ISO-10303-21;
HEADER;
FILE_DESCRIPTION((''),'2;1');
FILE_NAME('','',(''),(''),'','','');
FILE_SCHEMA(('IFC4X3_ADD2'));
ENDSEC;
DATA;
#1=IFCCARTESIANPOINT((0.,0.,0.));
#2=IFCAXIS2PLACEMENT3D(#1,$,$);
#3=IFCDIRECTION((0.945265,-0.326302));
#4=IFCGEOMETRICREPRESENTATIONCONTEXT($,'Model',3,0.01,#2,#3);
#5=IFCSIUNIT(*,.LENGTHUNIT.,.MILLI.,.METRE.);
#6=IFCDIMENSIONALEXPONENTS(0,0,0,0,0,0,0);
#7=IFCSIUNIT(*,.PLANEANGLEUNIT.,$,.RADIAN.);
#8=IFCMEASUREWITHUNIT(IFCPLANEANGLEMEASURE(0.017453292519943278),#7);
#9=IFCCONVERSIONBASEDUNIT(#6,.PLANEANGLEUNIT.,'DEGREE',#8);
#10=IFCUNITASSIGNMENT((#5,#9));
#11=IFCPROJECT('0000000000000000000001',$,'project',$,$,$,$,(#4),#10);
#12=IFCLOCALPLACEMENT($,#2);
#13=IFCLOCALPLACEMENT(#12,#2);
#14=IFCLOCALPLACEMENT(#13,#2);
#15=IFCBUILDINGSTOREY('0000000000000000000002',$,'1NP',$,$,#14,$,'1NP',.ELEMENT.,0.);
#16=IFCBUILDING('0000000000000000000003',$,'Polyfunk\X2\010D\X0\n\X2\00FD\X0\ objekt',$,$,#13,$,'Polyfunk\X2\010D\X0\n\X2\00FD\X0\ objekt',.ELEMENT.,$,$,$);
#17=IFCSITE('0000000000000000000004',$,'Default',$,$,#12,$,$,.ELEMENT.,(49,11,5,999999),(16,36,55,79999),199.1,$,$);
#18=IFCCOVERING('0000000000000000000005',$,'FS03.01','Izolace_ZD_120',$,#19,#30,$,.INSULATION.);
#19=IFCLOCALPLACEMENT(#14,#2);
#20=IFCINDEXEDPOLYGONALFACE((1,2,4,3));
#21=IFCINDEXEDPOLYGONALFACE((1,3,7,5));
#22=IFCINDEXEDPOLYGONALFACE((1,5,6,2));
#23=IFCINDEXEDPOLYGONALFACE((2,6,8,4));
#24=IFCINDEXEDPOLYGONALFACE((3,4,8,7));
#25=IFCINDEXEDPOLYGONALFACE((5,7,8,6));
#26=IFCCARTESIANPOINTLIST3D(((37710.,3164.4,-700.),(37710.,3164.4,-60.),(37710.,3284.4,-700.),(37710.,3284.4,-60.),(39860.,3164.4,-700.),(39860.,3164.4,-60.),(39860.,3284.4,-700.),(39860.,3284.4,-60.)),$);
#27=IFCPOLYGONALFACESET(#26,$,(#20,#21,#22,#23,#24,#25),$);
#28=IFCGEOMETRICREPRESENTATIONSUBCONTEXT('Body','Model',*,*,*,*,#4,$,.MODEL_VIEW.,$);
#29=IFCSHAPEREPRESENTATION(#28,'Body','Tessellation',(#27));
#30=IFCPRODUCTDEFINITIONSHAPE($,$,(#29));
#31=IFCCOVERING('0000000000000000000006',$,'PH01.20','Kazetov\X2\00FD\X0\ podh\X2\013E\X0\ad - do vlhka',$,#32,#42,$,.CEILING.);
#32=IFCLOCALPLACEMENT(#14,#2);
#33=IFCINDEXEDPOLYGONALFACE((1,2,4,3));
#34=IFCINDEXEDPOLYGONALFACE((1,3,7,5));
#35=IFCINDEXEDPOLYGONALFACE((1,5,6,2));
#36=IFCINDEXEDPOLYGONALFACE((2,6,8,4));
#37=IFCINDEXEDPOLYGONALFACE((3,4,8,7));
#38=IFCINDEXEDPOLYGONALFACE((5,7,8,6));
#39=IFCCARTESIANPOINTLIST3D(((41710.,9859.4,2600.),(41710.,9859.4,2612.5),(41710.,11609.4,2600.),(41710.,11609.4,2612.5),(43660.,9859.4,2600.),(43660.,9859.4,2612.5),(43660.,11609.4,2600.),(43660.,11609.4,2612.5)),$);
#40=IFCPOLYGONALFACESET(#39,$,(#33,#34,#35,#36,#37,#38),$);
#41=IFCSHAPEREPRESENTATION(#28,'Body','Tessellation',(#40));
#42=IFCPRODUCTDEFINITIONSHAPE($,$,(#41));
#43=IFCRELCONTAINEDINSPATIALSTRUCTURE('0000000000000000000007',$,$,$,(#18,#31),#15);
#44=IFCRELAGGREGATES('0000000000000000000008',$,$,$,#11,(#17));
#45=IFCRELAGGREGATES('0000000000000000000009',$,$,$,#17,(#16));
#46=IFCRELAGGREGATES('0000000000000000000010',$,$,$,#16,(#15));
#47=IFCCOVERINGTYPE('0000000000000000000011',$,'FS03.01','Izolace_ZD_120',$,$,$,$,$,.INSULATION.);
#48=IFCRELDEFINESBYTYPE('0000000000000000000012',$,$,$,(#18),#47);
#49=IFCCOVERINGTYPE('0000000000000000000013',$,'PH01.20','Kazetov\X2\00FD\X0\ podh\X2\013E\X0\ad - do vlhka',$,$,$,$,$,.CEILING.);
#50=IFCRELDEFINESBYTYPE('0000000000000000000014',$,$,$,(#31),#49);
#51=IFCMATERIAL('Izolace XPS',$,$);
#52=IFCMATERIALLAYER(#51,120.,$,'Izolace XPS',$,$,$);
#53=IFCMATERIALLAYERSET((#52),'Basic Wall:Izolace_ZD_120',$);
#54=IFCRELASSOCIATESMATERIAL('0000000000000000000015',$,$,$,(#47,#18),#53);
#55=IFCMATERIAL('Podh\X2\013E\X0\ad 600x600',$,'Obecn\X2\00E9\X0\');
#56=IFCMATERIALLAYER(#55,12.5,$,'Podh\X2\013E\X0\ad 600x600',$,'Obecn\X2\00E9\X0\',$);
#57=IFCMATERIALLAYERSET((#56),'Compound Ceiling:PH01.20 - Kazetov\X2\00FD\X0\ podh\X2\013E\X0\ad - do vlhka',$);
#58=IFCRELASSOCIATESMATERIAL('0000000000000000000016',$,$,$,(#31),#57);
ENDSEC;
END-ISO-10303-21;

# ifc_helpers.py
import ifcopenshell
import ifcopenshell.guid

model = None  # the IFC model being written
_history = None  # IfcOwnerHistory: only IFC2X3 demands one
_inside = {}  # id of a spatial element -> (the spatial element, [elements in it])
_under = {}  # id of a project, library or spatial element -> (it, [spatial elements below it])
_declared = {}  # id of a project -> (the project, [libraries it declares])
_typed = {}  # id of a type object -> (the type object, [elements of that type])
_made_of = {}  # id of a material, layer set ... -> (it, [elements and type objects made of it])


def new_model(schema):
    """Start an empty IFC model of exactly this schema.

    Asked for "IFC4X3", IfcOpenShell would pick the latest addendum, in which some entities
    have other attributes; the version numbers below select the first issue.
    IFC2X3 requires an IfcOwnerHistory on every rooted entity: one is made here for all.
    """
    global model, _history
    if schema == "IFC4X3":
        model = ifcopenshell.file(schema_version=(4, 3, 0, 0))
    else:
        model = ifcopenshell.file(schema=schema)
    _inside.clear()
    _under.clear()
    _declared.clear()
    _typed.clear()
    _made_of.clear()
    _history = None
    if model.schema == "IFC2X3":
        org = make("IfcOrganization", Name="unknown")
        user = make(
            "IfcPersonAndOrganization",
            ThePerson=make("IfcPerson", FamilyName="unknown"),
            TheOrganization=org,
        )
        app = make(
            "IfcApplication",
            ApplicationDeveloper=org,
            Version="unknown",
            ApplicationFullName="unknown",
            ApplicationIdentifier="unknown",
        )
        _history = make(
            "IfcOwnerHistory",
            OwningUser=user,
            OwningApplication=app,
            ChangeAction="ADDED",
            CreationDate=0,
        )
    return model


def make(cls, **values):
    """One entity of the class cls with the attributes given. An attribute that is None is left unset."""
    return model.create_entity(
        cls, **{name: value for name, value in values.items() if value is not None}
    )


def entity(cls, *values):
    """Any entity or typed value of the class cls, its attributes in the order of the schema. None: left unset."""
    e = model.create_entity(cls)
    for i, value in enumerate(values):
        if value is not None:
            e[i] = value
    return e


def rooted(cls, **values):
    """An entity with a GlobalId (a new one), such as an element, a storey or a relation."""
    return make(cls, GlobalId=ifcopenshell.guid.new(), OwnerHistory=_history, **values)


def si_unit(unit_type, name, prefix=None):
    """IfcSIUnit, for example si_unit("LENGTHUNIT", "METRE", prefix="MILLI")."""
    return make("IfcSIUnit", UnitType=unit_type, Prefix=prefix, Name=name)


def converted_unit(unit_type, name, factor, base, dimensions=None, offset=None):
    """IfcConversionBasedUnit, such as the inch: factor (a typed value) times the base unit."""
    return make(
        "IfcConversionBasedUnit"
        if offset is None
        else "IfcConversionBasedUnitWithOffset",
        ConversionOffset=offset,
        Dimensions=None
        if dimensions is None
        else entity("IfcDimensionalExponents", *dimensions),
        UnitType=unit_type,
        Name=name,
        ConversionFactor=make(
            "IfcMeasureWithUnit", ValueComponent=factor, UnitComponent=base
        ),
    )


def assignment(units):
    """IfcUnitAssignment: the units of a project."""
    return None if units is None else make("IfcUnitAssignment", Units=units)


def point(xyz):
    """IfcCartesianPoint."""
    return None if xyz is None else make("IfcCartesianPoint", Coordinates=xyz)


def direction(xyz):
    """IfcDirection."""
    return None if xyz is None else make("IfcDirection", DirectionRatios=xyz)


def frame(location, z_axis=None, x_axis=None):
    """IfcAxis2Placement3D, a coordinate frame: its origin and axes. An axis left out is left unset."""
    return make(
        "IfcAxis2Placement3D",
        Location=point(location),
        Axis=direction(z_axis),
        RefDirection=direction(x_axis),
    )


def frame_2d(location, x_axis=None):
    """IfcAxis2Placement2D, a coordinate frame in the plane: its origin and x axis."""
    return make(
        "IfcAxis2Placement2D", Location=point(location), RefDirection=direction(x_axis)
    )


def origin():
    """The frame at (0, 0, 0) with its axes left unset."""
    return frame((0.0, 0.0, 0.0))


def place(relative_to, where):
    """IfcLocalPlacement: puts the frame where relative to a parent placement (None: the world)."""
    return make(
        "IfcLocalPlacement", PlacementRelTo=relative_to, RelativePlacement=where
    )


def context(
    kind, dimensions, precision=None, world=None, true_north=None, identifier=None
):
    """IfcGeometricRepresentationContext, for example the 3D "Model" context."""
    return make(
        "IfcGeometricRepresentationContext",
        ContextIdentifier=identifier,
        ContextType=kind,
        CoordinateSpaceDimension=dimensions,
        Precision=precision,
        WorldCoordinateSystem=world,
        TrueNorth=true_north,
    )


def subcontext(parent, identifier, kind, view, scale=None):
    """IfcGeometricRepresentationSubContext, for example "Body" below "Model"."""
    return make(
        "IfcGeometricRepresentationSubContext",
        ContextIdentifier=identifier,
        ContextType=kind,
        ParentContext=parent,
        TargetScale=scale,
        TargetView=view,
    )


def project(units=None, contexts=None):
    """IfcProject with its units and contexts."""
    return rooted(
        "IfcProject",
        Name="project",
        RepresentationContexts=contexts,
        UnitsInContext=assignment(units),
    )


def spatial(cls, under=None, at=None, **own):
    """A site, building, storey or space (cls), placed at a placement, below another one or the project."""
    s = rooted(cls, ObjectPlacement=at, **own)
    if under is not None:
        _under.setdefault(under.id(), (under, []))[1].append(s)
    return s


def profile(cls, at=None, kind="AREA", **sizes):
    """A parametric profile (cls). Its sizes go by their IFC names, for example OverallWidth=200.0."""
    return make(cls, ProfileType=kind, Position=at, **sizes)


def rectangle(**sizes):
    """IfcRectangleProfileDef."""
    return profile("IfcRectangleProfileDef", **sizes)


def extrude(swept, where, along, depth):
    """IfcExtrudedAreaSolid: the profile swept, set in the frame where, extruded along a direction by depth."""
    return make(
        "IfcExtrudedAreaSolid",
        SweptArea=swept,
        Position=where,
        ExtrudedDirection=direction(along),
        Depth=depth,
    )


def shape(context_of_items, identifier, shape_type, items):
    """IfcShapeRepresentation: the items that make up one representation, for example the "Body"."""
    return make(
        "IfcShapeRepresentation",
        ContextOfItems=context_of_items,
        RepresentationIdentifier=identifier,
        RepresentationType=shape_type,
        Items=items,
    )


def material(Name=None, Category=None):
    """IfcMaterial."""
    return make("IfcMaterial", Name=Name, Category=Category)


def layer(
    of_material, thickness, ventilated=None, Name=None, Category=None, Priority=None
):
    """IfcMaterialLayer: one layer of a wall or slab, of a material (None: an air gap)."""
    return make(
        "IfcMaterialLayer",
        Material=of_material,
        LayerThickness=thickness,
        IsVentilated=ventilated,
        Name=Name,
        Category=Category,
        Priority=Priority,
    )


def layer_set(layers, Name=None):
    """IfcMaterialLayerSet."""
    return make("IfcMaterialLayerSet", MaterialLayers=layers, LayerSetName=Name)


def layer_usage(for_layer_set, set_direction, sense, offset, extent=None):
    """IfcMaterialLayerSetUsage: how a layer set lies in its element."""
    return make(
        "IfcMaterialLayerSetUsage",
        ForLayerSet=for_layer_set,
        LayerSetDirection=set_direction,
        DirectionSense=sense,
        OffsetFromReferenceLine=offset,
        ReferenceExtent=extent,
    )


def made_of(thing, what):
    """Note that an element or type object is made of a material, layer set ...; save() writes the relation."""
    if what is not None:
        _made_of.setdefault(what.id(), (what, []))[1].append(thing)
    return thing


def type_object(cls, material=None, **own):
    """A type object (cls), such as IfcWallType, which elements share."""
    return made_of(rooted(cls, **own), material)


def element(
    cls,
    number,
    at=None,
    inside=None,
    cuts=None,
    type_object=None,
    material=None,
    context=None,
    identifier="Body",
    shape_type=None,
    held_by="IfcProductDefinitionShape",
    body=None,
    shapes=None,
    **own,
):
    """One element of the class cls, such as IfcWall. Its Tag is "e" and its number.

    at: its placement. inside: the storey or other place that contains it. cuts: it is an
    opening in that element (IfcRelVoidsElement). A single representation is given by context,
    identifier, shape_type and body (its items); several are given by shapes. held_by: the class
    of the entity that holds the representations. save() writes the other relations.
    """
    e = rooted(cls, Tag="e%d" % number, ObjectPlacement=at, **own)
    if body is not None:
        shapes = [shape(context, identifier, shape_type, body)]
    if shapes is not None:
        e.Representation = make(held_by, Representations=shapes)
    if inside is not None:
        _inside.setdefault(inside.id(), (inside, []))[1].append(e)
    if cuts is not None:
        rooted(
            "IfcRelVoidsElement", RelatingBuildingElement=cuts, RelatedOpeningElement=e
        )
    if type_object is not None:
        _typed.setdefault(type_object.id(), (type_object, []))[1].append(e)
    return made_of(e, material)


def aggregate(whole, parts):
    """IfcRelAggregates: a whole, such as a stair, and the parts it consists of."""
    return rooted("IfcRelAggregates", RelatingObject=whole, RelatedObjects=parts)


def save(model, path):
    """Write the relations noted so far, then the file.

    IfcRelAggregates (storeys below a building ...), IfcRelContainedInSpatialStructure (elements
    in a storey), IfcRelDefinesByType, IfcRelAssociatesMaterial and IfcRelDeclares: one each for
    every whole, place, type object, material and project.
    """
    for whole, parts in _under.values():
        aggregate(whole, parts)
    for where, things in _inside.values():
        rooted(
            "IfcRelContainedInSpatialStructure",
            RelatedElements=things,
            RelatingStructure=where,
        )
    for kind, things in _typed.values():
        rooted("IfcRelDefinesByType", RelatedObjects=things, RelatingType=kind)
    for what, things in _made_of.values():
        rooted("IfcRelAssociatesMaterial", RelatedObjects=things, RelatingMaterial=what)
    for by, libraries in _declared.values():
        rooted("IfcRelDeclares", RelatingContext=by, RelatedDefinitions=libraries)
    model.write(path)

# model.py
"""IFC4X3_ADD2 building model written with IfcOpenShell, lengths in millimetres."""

from ifc_helpers import new_model, entity, si_unit, converted_unit, direction, frame, frame_2d, origin, place, context, subcontext, project, spatial, rectangle, extrude, material, layer, layer_set, layer_usage, type_object, element, save


model = new_model("IFC4X3_ADD2")

# Units and contexts
model_context = context("Model", 3, precision=0.01, world=origin(), true_north=direction((0.945265, -0.326302)))
body_context = subcontext(model_context, "Body", "Model", "MODEL_VIEW")
ifc_project = project(units=[si_unit("LENGTHUNIT", "METRE", prefix="MILLI"), converted_unit("PLANEANGLEUNIT", "DEGREE", entity("IfcPlaneAngleMeasure", 0.017453292519943278), si_unit("PLANEANGLEUNIT", "RADIAN"), dimensions=[0, 0, 0, 0, 0, 0, 0])], contexts=[model_context])

# Site, building, storey
site_placement = place(None, origin())
site = spatial("IfcSite", under=ifc_project, at=site_placement, Name="Default", CompositionType="ELEMENT", RefLatitude=(49, 11, 5, 999999), RefLongitude=(16, 36, 55, 79999), RefElevation=199.1)
building_placement = place(site_placement, origin())
building = spatial("IfcBuilding", under=site, at=building_placement, Name="Polyfunkčný objekt", LongName="Polyfunkčný objekt", CompositionType="ELEMENT")
storey_placement = place(building_placement, origin())
storey = spatial("IfcBuildingStorey", under=building, at=storey_placement, Name="1NP", LongName="1NP", CompositionType="ELEMENT", Elevation=0.0)

# Coverings
ifc_material_1 = material(Name="Podhľad 600x600", Category="Obecné")
ifc_material_2 = material(Name="Izolace XPS")
ifc_layer_1 = layer(ifc_material_2, 120.0, Name="Izolace XPS")
ifc_layer_set_1 = layer_set([ifc_layer_1], Name="Basic Wall:Izolace_ZD_120")
covering_type_1 = type_object("IfcCoveringType", Name="FS03.01", Description="Izolace_ZD_120", PredefinedType="INSULATION", material=ifc_layer_set_1)
covering_1_placement = place(storey_placement, frame((37710.0, 3224.4, -700.0)))
element("IfcCovering", 1, at=covering_1_placement, inside=storey, type_object=covering_type_1, material=ifc_layer_set_1, Name="FS03.01", Description="Izolace_ZD_120", PredefinedType="INSULATION", context=body_context, shape_type="SweptSolid", body=[
    extrude(rectangle(XDim=2150.0, YDim=120.0, at=frame_2d((1075.0, 0.0), x_axis=(-1.0, 0.0))), origin(), (0.0, 0.0, 1.0), 640.0),
])
ifc_layer_2 = layer(ifc_material_1, 12.5, Name="Podhľad 600x600", Category="Obecné")
ifc_layer_set_2 = layer_set([ifc_layer_2], Name="Compound Ceiling:PH01.20 - Kazetový podhľad - do vlhka")
ifc_layer_usage_1 = layer_usage(ifc_layer_set_2, "AXIS3", "NEGATIVE", 0.0)
covering_type_2 = type_object("IfcCoveringType", Name="PH01.20", Description="Kazetový podhľad - do vlhka", PredefinedType="CEILING")
covering_2_placement = place(storey_placement, frame((41710.0, 9859.4, 2600.0)))
element("IfcCovering", 2, at=covering_2_placement, inside=storey, type_object=covering_type_2, material=ifc_layer_usage_1, Name="PH01.20", Description="Kazetový podhľad - do vlhka", PredefinedType="CEILING", context=body_context, shape_type="SweptSolid", body=[
    extrude(rectangle(XDim=1950.0, YDim=1750.0, at=frame_2d((0.0, 0.0), x_axis=(1.0, 0.0))), frame((975.0, 875.0, 0.0), z_axis=(0.0, 0.0, 1.0), x_axis=(-1.0, 0.0, 0.0)), (0.0, 0.0, 1.0), 12.5),
])

save(model, "model.ifc")
